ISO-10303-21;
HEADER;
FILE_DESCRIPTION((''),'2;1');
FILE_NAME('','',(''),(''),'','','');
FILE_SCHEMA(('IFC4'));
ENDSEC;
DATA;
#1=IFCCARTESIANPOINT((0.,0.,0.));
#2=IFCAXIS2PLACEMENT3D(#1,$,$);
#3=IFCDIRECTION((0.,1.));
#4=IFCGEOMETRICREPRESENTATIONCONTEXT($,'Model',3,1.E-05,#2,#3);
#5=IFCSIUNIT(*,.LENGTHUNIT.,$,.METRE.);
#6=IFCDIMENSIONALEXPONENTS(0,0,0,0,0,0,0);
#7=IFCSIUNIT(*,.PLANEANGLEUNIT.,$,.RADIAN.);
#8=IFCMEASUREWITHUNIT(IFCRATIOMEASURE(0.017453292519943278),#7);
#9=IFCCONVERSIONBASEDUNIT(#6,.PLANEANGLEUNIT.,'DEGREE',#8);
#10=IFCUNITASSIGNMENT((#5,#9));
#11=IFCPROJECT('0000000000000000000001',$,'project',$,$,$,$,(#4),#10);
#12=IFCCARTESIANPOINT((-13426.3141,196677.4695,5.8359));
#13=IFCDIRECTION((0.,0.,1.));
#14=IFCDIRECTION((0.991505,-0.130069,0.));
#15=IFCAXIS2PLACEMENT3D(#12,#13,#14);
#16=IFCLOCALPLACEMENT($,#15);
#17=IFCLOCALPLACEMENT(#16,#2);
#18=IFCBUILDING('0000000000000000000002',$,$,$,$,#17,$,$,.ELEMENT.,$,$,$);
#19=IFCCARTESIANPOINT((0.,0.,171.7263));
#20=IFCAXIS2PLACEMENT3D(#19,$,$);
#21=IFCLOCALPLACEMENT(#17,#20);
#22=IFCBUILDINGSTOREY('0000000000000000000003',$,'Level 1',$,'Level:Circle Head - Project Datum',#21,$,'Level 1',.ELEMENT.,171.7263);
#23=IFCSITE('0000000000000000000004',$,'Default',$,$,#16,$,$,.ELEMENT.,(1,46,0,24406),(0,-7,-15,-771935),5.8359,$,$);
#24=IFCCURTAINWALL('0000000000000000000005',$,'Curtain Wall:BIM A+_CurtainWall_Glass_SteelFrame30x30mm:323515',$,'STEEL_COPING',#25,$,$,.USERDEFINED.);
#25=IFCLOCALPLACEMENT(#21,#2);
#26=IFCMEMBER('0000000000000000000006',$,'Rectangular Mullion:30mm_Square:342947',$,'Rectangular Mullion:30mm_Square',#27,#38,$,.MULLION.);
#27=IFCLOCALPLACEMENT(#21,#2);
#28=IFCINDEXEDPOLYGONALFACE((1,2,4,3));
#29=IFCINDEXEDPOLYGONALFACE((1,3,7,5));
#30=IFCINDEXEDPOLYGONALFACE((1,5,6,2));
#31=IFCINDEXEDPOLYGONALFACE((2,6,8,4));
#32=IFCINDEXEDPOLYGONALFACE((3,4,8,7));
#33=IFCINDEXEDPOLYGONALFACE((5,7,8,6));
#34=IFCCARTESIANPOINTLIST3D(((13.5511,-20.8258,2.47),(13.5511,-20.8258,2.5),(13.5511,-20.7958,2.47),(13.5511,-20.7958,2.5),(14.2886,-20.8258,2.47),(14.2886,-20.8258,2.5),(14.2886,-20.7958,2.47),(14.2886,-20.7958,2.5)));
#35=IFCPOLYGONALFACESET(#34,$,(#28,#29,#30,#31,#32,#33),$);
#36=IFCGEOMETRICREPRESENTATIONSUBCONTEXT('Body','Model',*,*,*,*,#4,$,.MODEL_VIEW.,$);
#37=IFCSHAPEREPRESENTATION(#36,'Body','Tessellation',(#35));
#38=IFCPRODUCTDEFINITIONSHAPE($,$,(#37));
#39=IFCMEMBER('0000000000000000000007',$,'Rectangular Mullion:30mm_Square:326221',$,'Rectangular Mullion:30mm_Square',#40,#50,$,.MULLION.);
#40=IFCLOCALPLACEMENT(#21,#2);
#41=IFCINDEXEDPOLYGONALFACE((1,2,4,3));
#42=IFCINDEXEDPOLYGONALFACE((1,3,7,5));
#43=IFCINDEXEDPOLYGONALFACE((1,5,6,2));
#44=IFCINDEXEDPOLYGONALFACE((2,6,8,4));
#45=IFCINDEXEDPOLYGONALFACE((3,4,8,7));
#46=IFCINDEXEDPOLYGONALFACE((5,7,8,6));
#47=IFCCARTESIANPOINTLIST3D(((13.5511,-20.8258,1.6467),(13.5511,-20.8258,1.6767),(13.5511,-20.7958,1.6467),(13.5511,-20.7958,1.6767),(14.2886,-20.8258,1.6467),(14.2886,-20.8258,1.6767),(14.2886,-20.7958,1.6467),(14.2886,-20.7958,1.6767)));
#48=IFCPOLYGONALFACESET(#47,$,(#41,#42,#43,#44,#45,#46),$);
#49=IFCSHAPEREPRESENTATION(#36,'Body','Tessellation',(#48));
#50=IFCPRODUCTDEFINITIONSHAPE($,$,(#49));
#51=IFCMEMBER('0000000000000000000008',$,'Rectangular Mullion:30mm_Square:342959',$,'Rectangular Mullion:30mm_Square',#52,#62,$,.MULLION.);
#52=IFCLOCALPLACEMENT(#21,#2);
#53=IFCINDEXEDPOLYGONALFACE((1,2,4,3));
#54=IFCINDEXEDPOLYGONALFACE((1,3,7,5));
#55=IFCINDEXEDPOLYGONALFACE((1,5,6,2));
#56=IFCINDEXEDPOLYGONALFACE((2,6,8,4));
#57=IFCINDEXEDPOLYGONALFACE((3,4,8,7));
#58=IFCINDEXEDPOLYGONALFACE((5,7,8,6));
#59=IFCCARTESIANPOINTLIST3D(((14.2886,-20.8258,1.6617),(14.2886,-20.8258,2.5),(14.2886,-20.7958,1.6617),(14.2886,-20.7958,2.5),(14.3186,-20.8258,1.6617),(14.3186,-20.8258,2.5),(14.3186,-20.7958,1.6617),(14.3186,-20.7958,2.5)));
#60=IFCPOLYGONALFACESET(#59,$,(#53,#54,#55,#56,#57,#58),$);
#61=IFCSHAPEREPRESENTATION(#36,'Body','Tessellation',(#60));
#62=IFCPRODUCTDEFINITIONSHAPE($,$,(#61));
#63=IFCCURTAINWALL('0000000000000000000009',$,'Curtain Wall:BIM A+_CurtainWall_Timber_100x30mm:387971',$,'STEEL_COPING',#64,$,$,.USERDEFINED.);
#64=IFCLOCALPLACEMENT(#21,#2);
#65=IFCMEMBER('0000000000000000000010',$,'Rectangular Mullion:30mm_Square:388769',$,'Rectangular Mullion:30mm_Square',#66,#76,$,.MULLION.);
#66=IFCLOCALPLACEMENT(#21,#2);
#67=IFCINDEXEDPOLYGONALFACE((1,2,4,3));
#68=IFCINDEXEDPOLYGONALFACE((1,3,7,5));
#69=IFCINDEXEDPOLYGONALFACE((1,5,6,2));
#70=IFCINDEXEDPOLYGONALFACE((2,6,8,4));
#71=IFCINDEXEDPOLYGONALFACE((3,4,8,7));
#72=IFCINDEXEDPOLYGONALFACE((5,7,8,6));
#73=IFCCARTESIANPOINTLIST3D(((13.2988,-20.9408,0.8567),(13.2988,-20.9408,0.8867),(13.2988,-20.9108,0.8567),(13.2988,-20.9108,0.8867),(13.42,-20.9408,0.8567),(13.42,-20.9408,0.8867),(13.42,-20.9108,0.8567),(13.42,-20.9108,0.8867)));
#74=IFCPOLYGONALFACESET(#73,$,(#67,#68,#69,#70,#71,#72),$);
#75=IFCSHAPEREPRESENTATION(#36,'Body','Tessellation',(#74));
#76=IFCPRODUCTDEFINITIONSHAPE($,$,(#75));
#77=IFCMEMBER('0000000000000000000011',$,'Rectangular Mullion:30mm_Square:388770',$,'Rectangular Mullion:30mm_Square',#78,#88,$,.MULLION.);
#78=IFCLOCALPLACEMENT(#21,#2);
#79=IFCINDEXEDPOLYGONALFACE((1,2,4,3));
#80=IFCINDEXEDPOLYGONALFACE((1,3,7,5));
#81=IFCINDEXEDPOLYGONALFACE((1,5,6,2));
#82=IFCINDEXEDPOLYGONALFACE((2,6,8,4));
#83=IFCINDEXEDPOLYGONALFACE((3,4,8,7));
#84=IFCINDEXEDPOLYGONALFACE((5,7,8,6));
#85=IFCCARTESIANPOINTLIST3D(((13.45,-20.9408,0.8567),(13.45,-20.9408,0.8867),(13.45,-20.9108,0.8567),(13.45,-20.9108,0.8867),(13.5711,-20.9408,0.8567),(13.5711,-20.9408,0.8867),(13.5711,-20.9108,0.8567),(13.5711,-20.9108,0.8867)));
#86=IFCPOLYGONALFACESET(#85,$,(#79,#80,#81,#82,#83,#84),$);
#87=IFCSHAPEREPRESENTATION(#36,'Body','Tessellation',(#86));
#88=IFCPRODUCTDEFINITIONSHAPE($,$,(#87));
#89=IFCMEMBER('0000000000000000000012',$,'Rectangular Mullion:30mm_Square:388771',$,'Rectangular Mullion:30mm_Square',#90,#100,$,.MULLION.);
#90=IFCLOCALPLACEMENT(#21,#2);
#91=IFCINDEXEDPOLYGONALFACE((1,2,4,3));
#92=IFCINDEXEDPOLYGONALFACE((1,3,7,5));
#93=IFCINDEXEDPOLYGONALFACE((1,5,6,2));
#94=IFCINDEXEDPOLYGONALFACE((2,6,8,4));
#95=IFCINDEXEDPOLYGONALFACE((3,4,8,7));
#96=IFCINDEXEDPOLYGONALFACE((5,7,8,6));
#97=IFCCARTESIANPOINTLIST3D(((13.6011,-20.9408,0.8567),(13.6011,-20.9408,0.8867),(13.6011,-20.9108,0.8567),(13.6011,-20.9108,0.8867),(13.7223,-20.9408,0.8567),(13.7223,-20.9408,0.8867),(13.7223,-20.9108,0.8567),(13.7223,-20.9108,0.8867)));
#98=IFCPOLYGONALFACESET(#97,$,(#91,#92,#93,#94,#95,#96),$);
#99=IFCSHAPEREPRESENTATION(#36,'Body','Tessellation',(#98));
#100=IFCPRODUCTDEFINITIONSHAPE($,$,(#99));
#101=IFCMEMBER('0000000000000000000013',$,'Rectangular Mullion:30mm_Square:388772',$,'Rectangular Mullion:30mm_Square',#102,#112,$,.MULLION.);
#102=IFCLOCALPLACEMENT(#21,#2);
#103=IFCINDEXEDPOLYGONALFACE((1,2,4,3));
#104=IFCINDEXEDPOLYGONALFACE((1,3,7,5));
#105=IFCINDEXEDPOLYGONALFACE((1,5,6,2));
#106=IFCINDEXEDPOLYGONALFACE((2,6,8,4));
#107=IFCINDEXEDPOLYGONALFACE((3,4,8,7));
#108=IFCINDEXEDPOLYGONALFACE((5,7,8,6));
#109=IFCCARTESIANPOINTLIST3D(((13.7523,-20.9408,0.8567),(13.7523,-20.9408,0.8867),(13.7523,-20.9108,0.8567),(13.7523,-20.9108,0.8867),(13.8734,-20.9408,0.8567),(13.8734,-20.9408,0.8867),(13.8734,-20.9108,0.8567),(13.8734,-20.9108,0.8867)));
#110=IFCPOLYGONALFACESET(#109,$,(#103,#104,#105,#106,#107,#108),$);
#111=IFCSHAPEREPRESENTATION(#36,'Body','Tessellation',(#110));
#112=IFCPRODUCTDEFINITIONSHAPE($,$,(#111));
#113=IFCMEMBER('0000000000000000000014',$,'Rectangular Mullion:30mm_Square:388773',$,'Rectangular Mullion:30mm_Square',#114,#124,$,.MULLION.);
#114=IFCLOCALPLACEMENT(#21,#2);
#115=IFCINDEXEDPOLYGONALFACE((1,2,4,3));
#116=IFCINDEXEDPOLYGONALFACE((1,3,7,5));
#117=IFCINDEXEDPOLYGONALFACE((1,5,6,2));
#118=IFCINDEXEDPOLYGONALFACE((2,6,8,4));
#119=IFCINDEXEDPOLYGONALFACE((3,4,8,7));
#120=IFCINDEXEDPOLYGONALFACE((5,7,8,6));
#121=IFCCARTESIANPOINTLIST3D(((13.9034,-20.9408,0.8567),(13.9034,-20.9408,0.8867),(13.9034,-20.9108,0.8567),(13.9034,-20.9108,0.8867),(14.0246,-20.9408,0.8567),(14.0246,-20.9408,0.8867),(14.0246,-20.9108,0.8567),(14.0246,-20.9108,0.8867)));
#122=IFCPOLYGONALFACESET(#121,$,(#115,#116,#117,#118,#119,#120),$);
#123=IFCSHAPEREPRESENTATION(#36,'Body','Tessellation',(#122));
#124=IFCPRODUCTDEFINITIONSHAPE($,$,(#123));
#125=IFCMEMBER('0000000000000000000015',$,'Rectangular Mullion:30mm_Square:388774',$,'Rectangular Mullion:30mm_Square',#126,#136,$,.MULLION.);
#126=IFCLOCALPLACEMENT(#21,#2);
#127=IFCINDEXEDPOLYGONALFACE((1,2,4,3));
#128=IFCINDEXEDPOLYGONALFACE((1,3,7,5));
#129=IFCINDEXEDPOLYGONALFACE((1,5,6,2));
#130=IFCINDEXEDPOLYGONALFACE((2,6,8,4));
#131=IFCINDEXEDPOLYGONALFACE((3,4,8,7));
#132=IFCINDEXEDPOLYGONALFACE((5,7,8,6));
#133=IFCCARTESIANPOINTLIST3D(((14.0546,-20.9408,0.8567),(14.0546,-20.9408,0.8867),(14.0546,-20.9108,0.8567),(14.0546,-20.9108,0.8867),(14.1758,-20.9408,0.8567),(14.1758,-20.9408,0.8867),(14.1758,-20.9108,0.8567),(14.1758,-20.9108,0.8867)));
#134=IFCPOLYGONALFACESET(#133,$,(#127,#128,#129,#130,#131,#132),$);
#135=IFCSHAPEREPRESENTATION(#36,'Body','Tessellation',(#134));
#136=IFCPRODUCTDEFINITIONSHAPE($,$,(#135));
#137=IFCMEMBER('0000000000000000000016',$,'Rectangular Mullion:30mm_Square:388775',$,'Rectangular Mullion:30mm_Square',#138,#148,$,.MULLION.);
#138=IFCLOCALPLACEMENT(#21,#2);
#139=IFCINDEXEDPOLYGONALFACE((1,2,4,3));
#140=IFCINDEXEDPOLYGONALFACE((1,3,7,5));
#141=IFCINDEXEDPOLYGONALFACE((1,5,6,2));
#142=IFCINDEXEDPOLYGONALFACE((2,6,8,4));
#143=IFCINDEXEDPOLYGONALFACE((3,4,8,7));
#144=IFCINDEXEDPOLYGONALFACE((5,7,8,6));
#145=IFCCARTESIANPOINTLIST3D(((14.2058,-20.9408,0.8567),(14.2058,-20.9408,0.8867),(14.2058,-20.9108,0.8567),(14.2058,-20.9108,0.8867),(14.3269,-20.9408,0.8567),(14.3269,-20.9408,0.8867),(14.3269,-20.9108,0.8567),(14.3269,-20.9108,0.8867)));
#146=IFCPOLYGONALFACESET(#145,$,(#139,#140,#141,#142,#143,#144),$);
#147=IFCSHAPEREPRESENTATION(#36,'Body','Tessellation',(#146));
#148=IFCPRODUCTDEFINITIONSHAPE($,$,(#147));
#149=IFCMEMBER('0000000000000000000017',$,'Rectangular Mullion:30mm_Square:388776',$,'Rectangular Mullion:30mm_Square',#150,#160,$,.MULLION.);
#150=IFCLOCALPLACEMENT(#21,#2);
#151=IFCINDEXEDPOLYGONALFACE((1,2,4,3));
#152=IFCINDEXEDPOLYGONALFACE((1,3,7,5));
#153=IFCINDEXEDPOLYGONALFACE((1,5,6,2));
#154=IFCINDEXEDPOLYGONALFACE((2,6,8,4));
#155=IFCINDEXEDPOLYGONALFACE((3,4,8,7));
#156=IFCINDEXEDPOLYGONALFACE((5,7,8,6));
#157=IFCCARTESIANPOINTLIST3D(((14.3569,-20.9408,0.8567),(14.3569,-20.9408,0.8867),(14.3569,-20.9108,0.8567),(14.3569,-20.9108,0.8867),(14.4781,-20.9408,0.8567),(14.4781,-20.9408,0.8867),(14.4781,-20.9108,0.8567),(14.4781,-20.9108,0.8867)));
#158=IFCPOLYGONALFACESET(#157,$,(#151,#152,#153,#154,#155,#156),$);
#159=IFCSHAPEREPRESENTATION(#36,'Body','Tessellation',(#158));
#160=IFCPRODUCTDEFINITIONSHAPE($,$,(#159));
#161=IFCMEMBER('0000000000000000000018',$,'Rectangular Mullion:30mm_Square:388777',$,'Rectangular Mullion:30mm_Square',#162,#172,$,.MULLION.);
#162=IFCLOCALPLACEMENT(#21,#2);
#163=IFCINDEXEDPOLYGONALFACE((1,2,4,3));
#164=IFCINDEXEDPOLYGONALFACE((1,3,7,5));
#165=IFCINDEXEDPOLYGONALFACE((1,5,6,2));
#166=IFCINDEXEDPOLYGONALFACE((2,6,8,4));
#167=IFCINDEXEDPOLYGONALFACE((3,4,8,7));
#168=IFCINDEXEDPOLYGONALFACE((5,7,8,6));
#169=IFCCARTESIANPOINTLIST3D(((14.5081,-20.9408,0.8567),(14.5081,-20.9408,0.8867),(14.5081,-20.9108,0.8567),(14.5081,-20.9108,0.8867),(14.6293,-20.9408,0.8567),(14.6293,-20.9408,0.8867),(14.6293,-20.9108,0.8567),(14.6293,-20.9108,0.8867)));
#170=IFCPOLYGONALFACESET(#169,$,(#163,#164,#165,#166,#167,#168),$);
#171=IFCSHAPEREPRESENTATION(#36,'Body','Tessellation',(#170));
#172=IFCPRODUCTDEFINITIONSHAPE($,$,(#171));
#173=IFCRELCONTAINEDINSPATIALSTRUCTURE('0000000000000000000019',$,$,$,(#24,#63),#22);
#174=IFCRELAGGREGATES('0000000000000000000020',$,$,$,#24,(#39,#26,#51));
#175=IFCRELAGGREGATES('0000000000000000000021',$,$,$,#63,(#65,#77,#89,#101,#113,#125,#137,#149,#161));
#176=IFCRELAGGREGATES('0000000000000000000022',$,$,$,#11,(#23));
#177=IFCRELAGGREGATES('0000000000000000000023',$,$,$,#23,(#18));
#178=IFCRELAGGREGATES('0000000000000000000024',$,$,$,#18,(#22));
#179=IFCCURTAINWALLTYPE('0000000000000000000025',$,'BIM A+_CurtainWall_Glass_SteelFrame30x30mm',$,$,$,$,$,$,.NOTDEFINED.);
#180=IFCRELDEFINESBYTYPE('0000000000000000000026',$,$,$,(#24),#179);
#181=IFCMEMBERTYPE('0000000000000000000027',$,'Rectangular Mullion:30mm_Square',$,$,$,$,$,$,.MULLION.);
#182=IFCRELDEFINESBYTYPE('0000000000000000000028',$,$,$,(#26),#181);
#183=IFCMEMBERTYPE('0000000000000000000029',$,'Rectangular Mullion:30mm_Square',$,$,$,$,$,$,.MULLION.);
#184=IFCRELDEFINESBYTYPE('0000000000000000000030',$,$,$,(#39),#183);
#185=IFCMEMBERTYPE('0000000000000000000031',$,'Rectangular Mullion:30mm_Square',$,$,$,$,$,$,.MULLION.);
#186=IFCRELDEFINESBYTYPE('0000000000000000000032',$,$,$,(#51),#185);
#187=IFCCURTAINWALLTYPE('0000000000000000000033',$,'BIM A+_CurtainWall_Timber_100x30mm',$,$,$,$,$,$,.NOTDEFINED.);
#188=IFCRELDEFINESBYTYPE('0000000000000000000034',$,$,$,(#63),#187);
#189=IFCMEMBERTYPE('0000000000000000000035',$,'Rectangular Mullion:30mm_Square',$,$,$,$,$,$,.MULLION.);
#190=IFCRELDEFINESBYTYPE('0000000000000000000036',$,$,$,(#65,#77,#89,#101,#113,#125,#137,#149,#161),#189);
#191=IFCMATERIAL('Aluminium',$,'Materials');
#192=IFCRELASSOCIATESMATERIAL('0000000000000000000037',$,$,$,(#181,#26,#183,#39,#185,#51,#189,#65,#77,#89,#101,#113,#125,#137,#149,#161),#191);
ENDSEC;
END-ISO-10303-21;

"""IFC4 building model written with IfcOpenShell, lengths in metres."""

from ifc_helpers import new_model, entity, si_unit, converted_unit, direction, frame, origin, place, context, subcontext, project, spatial, indexed_curve, outline, extrude, source, transform, mapped, material, type_object, type_shapes, element, aggregate, save


model = new_model("IFC4")

# Units and contexts
model_context = context("Model", 3, precision=1e-05, world=origin(), true_north=direction((0.0, 1.0)))
body_context = subcontext(model_context, "Body", "Model", "MODEL_VIEW")
ifc_project = project(units=[si_unit("LENGTHUNIT", "METRE"), converted_unit("PLANEANGLEUNIT", "DEGREE", entity("IfcRatioMeasure", 0.017453292519943278), si_unit("PLANEANGLEUNIT", "RADIAN"), dimensions=[0, 0, 0, 0, 0, 0, 0])], contexts=[model_context])

# Site, building, storey
site_placement = place(None, frame((-13426.3141, 196677.4695, 5.8359), z_axis=(0.0, 0.0, 1.0), x_axis=(0.991505, -0.130069, 0.0)))
site = spatial("IfcSite", under=ifc_project, at=site_placement, Name="Default", CompositionType="ELEMENT", RefLatitude=(1, 46, 0, 24406), RefLongitude=(0, -7, -15, -771935), RefElevation=5.8359)
building_placement = place(site_placement, origin())
building = spatial("IfcBuilding", under=site, at=building_placement, CompositionType="ELEMENT")
storey_placement = place(building_placement, frame((0.0, 0.0, 171.7263)))
storey = spatial("IfcBuildingStorey", under=building, at=storey_placement, Name="Level 1", ObjectType="Level:Circle Head - Project Datum", LongName="Level 1", CompositionType="ELEMENT", Elevation=171.7263)

# Curtain walls, members
curtain_wall_type_1 = type_object("IfcCurtainWallType", Name="BIM A+_CurtainWall_Glass_SteelFrame30x30mm", PredefinedType="NOTDEFINED")
curtain_wall_1_placement = place(storey_placement, frame((0.0, 0.0, -171.7263)))
curtain_wall_1 = element("IfcCurtainWall", 1, at=curtain_wall_1_placement, inside=storey, type_object=curtain_wall_type_1, Name="Curtain Wall:BIM A+_CurtainWall_Glass_SteelFrame30x30mm:323515", ObjectType="STEEL_COPING", PredefinedType="USERDEFINED")
ifc_material_1 = material(Name="Aluminium", Category="Materials")
member_type_1 = type_object("IfcMemberType", Name="Rectangular Mullion:30mm_Square", PredefinedType="MULLION", material=ifc_material_1)
shared_shape_1 = source(origin(), body_context, "Body", "SweptSolid", [
    extrude(outline(indexed_curve([(-0.015, -0.015), (0.015, -0.015), (0.015, 0.015), (-0.015, 0.015), (-0.015, -0.015)], self_intersect=False)), frame((-0.015, 0.0, -0.7375), z_axis=(0.0, 0.0, 1.0), x_axis=(0.0, -1.0, 0.0)), (0.0, 0.0, 1.0), 0.7375),
])
type_shapes(member_type_1, [shared_shape_1])
member_1_placement = place(curtain_wall_1_placement, frame((14.2886, -20.8108, 174.2263), z_axis=(1.0, 0.0, 0.0), x_axis=(0.0, 0.0, 1.0)))
member_1 = element("IfcMember", 2, at=member_1_placement, type_object=member_type_1, material=ifc_material_1, Name="Rectangular Mullion:30mm_Square:342947", ObjectType="Rectangular Mullion:30mm_Square", PredefinedType="MULLION", context=body_context, shape_type="MappedRepresentation", body=[
    mapped(shared_shape_1, transform((0.0, 0.0, 0.0), scale=1.0)),
])
member_type_2 = type_object("IfcMemberType", Name="Rectangular Mullion:30mm_Square", PredefinedType="MULLION", material=ifc_material_1)
shared_shape_2 = source(origin(), body_context, "Body", "SweptSolid", [
    extrude(outline(indexed_curve([(-0.015, -0.015), (0.015, -0.015), (0.015, 0.015), (-0.015, 0.015), (-0.015, -0.015)], self_intersect=False)), frame((0.0, 0.0, -0.7375), z_axis=(0.0, 0.0, 1.0), x_axis=(0.0, -1.0, 0.0)), (0.0, 0.0, 1.0), 0.7375),
])
type_shapes(member_type_2, [shared_shape_2])
member_2_placement = place(curtain_wall_1_placement, frame((14.2886, -20.8108, 173.3879), z_axis=(1.0, 0.0, 0.0), x_axis=(0.0, 0.0, 1.0)))
member_2 = element("IfcMember", 3, at=member_2_placement, type_object=member_type_2, material=ifc_material_1, Name="Rectangular Mullion:30mm_Square:326221", ObjectType="Rectangular Mullion:30mm_Square", PredefinedType="MULLION", context=body_context, shape_type="MappedRepresentation", body=[
    mapped(shared_shape_2, transform((0.0, 0.0, 0.0), scale=1.0)),
])
member_type_3 = type_object("IfcMemberType", Name="Rectangular Mullion:30mm_Square", PredefinedType="MULLION", material=ifc_material_1)
shared_shape_3 = source(origin(), body_context, "Body", "SweptSolid", [
    extrude(outline(indexed_curve([(-0.015, -0.015), (0.015, -0.015), (0.015, 0.015), (-0.015, 0.015), (-0.015, -0.015)], self_intersect=False)), frame((0.0, 0.0, -0.8383), z_axis=(0.0, 0.0, 1.0), x_axis=(0.0, -1.0, 0.0)), (0.0, 0.0, 1.0), 0.8383),
])
type_shapes(member_type_3, [shared_shape_3])
member_3_placement = place(curtain_wall_1_placement, frame((14.3036, -20.8108, 173.3879), z_axis=(0.0, 0.0, -1.0), x_axis=(1.0, 0.0, 0.0)))
member_3 = element("IfcMember", 4, at=member_3_placement, type_object=member_type_3, material=ifc_material_1, Name="Rectangular Mullion:30mm_Square:342959", ObjectType="Rectangular Mullion:30mm_Square", PredefinedType="MULLION", context=body_context, shape_type="MappedRepresentation", body=[
    mapped(shared_shape_3, transform((0.0, 0.0, 0.0), scale=1.0)),
])
curtain_wall_type_2 = type_object("IfcCurtainWallType", Name="BIM A+_CurtainWall_Timber_100x30mm", PredefinedType="NOTDEFINED")
curtain_wall_2_placement = place(storey_placement, frame((0.0, 0.0, -171.7263)))
curtain_wall_2 = element("IfcCurtainWall", 5, at=curtain_wall_2_placement, inside=storey, type_object=curtain_wall_type_2, Name="Curtain Wall:BIM A+_CurtainWall_Timber_100x30mm:387971", ObjectType="STEEL_COPING", PredefinedType="USERDEFINED")
member_type_4 = type_object("IfcMemberType", Name="Rectangular Mullion:30mm_Square", PredefinedType="MULLION", material=ifc_material_1)
shared_shape_4 = source(origin(), body_context, "Body", "SweptSolid", [
    extrude(outline(indexed_curve([(-0.015, -0.015), (0.015, -0.015), (0.015, 0.015), (-0.015, 0.015), (-0.015, -0.015)], self_intersect=False)), frame((0.0, 0.0, -0.1212), z_axis=(0.0, 0.0, 1.0), x_axis=(0.0, -1.0, 0.0)), (0.0, 0.0, 1.0), 0.1212),
])
type_shapes(member_type_4, [shared_shape_4])
member_4_placement = place(curtain_wall_2_placement, frame((13.42, -20.9258, 172.598), z_axis=(1.0, 0.0, 0.0), x_axis=(0.0, 0.0, 1.0)))
member_4 = element("IfcMember", 6, at=member_4_placement, type_object=member_type_4, material=ifc_material_1, Name="Rectangular Mullion:30mm_Square:388769", ObjectType="Rectangular Mullion:30mm_Square", PredefinedType="MULLION", context=body_context, shape_type="MappedRepresentation", body=[
    mapped(shared_shape_4, transform((0.0, 0.0, 0.0), scale=1.0)),
])
member_5_placement = place(curtain_wall_2_placement, frame((13.5711, -20.9258, 172.598), z_axis=(1.0, 0.0, 0.0), x_axis=(0.0, 0.0, 1.0)))
member_5 = element("IfcMember", 7, at=member_5_placement, type_object=member_type_4, material=ifc_material_1, Name="Rectangular Mullion:30mm_Square:388770", ObjectType="Rectangular Mullion:30mm_Square", PredefinedType="MULLION", context=body_context, shape_type="MappedRepresentation", body=[
    mapped(shared_shape_4, transform((0.0, 0.0, 0.0), scale=1.0)),
])
member_6_placement = place(curtain_wall_2_placement, frame((13.7223, -20.9258, 172.598), z_axis=(1.0, 0.0, 0.0), x_axis=(0.0, 0.0, 1.0)))
member_6 = element("IfcMember", 8, at=member_6_placement, type_object=member_type_4, material=ifc_material_1, Name="Rectangular Mullion:30mm_Square:388771", ObjectType="Rectangular Mullion:30mm_Square", PredefinedType="MULLION", context=body_context, shape_type="MappedRepresentation", body=[
    mapped(shared_shape_4, transform((0.0, 0.0, 0.0), scale=1.0)),
])
member_7_placement = place(curtain_wall_2_placement, frame((13.8734, -20.9258, 172.598), z_axis=(1.0, 0.0, 0.0), x_axis=(0.0, 0.0, 1.0)))
member_7 = element("IfcMember", 9, at=member_7_placement, type_object=member_type_4, material=ifc_material_1, Name="Rectangular Mullion:30mm_Square:388772", ObjectType="Rectangular Mullion:30mm_Square", PredefinedType="MULLION", context=body_context, shape_type="MappedRepresentation", body=[
    mapped(shared_shape_4, transform((0.0, 0.0, 0.0), scale=1.0)),
])
member_8_placement = place(curtain_wall_2_placement, frame((14.0246, -20.9258, 172.598), z_axis=(1.0, 0.0, 0.0), x_axis=(0.0, 0.0, 1.0)))
member_8 = element("IfcMember", 10, at=member_8_placement, type_object=member_type_4, material=ifc_material_1, Name="Rectangular Mullion:30mm_Square:388773", ObjectType="Rectangular Mullion:30mm_Square", PredefinedType="MULLION", context=body_context, shape_type="MappedRepresentation", body=[
    mapped(shared_shape_4, transform((0.0, 0.0, 0.0), scale=1.0)),
])
member_9_placement = place(curtain_wall_2_placement, frame((14.1758, -20.9258, 172.598), z_axis=(1.0, 0.0, 0.0), x_axis=(0.0, 0.0, 1.0)))
member_9 = element("IfcMember", 11, at=member_9_placement, type_object=member_type_4, material=ifc_material_1, Name="Rectangular Mullion:30mm_Square:388774", ObjectType="Rectangular Mullion:30mm_Square", PredefinedType="MULLION", context=body_context, shape_type="MappedRepresentation", body=[
    mapped(shared_shape_4, transform((0.0, 0.0, 0.0), scale=1.0)),
])
member_10_placement = place(curtain_wall_2_placement, frame((14.3269, -20.9258, 172.598), z_axis=(1.0, 0.0, 0.0), x_axis=(0.0, 0.0, 1.0)))
member_10 = element("IfcMember", 12, at=member_10_placement, type_object=member_type_4, material=ifc_material_1, Name="Rectangular Mullion:30mm_Square:388775", ObjectType="Rectangular Mullion:30mm_Square", PredefinedType="MULLION", context=body_context, shape_type="MappedRepresentation", body=[
    mapped(shared_shape_4, transform((0.0, 0.0, 0.0), scale=1.0)),
])
member_11_placement = place(curtain_wall_2_placement, frame((14.4781, -20.9258, 172.598), z_axis=(1.0, 0.0, 0.0), x_axis=(0.0, 0.0, 1.0)))
member_11 = element("IfcMember", 13, at=member_11_placement, type_object=member_type_4, material=ifc_material_1, Name="Rectangular Mullion:30mm_Square:388776", ObjectType="Rectangular Mullion:30mm_Square", PredefinedType="MULLION", context=body_context, shape_type="MappedRepresentation", body=[
    mapped(shared_shape_4, transform((0.0, 0.0, 0.0), scale=1.0)),
])
member_12_placement = place(curtain_wall_2_placement, frame((14.6293, -20.9258, 172.598), z_axis=(1.0, 0.0, 0.0), x_axis=(0.0, 0.0, 1.0)))
member_12 = element("IfcMember", 14, at=member_12_placement, type_object=member_type_4, material=ifc_material_1, Name="Rectangular Mullion:30mm_Square:388777", ObjectType="Rectangular Mullion:30mm_Square", PredefinedType="MULLION", context=body_context, shape_type="MappedRepresentation", body=[
    mapped(shared_shape_4, transform((0.0, 0.0, 0.0), scale=1.0)),
])

aggregate(curtain_wall_1, [member_2, member_1, member_3])
aggregate(curtain_wall_2, [member_4, member_5, member_6, member_7, member_8, member_9, member_10, member_11, member_12])

save(model, "model.ifc")
